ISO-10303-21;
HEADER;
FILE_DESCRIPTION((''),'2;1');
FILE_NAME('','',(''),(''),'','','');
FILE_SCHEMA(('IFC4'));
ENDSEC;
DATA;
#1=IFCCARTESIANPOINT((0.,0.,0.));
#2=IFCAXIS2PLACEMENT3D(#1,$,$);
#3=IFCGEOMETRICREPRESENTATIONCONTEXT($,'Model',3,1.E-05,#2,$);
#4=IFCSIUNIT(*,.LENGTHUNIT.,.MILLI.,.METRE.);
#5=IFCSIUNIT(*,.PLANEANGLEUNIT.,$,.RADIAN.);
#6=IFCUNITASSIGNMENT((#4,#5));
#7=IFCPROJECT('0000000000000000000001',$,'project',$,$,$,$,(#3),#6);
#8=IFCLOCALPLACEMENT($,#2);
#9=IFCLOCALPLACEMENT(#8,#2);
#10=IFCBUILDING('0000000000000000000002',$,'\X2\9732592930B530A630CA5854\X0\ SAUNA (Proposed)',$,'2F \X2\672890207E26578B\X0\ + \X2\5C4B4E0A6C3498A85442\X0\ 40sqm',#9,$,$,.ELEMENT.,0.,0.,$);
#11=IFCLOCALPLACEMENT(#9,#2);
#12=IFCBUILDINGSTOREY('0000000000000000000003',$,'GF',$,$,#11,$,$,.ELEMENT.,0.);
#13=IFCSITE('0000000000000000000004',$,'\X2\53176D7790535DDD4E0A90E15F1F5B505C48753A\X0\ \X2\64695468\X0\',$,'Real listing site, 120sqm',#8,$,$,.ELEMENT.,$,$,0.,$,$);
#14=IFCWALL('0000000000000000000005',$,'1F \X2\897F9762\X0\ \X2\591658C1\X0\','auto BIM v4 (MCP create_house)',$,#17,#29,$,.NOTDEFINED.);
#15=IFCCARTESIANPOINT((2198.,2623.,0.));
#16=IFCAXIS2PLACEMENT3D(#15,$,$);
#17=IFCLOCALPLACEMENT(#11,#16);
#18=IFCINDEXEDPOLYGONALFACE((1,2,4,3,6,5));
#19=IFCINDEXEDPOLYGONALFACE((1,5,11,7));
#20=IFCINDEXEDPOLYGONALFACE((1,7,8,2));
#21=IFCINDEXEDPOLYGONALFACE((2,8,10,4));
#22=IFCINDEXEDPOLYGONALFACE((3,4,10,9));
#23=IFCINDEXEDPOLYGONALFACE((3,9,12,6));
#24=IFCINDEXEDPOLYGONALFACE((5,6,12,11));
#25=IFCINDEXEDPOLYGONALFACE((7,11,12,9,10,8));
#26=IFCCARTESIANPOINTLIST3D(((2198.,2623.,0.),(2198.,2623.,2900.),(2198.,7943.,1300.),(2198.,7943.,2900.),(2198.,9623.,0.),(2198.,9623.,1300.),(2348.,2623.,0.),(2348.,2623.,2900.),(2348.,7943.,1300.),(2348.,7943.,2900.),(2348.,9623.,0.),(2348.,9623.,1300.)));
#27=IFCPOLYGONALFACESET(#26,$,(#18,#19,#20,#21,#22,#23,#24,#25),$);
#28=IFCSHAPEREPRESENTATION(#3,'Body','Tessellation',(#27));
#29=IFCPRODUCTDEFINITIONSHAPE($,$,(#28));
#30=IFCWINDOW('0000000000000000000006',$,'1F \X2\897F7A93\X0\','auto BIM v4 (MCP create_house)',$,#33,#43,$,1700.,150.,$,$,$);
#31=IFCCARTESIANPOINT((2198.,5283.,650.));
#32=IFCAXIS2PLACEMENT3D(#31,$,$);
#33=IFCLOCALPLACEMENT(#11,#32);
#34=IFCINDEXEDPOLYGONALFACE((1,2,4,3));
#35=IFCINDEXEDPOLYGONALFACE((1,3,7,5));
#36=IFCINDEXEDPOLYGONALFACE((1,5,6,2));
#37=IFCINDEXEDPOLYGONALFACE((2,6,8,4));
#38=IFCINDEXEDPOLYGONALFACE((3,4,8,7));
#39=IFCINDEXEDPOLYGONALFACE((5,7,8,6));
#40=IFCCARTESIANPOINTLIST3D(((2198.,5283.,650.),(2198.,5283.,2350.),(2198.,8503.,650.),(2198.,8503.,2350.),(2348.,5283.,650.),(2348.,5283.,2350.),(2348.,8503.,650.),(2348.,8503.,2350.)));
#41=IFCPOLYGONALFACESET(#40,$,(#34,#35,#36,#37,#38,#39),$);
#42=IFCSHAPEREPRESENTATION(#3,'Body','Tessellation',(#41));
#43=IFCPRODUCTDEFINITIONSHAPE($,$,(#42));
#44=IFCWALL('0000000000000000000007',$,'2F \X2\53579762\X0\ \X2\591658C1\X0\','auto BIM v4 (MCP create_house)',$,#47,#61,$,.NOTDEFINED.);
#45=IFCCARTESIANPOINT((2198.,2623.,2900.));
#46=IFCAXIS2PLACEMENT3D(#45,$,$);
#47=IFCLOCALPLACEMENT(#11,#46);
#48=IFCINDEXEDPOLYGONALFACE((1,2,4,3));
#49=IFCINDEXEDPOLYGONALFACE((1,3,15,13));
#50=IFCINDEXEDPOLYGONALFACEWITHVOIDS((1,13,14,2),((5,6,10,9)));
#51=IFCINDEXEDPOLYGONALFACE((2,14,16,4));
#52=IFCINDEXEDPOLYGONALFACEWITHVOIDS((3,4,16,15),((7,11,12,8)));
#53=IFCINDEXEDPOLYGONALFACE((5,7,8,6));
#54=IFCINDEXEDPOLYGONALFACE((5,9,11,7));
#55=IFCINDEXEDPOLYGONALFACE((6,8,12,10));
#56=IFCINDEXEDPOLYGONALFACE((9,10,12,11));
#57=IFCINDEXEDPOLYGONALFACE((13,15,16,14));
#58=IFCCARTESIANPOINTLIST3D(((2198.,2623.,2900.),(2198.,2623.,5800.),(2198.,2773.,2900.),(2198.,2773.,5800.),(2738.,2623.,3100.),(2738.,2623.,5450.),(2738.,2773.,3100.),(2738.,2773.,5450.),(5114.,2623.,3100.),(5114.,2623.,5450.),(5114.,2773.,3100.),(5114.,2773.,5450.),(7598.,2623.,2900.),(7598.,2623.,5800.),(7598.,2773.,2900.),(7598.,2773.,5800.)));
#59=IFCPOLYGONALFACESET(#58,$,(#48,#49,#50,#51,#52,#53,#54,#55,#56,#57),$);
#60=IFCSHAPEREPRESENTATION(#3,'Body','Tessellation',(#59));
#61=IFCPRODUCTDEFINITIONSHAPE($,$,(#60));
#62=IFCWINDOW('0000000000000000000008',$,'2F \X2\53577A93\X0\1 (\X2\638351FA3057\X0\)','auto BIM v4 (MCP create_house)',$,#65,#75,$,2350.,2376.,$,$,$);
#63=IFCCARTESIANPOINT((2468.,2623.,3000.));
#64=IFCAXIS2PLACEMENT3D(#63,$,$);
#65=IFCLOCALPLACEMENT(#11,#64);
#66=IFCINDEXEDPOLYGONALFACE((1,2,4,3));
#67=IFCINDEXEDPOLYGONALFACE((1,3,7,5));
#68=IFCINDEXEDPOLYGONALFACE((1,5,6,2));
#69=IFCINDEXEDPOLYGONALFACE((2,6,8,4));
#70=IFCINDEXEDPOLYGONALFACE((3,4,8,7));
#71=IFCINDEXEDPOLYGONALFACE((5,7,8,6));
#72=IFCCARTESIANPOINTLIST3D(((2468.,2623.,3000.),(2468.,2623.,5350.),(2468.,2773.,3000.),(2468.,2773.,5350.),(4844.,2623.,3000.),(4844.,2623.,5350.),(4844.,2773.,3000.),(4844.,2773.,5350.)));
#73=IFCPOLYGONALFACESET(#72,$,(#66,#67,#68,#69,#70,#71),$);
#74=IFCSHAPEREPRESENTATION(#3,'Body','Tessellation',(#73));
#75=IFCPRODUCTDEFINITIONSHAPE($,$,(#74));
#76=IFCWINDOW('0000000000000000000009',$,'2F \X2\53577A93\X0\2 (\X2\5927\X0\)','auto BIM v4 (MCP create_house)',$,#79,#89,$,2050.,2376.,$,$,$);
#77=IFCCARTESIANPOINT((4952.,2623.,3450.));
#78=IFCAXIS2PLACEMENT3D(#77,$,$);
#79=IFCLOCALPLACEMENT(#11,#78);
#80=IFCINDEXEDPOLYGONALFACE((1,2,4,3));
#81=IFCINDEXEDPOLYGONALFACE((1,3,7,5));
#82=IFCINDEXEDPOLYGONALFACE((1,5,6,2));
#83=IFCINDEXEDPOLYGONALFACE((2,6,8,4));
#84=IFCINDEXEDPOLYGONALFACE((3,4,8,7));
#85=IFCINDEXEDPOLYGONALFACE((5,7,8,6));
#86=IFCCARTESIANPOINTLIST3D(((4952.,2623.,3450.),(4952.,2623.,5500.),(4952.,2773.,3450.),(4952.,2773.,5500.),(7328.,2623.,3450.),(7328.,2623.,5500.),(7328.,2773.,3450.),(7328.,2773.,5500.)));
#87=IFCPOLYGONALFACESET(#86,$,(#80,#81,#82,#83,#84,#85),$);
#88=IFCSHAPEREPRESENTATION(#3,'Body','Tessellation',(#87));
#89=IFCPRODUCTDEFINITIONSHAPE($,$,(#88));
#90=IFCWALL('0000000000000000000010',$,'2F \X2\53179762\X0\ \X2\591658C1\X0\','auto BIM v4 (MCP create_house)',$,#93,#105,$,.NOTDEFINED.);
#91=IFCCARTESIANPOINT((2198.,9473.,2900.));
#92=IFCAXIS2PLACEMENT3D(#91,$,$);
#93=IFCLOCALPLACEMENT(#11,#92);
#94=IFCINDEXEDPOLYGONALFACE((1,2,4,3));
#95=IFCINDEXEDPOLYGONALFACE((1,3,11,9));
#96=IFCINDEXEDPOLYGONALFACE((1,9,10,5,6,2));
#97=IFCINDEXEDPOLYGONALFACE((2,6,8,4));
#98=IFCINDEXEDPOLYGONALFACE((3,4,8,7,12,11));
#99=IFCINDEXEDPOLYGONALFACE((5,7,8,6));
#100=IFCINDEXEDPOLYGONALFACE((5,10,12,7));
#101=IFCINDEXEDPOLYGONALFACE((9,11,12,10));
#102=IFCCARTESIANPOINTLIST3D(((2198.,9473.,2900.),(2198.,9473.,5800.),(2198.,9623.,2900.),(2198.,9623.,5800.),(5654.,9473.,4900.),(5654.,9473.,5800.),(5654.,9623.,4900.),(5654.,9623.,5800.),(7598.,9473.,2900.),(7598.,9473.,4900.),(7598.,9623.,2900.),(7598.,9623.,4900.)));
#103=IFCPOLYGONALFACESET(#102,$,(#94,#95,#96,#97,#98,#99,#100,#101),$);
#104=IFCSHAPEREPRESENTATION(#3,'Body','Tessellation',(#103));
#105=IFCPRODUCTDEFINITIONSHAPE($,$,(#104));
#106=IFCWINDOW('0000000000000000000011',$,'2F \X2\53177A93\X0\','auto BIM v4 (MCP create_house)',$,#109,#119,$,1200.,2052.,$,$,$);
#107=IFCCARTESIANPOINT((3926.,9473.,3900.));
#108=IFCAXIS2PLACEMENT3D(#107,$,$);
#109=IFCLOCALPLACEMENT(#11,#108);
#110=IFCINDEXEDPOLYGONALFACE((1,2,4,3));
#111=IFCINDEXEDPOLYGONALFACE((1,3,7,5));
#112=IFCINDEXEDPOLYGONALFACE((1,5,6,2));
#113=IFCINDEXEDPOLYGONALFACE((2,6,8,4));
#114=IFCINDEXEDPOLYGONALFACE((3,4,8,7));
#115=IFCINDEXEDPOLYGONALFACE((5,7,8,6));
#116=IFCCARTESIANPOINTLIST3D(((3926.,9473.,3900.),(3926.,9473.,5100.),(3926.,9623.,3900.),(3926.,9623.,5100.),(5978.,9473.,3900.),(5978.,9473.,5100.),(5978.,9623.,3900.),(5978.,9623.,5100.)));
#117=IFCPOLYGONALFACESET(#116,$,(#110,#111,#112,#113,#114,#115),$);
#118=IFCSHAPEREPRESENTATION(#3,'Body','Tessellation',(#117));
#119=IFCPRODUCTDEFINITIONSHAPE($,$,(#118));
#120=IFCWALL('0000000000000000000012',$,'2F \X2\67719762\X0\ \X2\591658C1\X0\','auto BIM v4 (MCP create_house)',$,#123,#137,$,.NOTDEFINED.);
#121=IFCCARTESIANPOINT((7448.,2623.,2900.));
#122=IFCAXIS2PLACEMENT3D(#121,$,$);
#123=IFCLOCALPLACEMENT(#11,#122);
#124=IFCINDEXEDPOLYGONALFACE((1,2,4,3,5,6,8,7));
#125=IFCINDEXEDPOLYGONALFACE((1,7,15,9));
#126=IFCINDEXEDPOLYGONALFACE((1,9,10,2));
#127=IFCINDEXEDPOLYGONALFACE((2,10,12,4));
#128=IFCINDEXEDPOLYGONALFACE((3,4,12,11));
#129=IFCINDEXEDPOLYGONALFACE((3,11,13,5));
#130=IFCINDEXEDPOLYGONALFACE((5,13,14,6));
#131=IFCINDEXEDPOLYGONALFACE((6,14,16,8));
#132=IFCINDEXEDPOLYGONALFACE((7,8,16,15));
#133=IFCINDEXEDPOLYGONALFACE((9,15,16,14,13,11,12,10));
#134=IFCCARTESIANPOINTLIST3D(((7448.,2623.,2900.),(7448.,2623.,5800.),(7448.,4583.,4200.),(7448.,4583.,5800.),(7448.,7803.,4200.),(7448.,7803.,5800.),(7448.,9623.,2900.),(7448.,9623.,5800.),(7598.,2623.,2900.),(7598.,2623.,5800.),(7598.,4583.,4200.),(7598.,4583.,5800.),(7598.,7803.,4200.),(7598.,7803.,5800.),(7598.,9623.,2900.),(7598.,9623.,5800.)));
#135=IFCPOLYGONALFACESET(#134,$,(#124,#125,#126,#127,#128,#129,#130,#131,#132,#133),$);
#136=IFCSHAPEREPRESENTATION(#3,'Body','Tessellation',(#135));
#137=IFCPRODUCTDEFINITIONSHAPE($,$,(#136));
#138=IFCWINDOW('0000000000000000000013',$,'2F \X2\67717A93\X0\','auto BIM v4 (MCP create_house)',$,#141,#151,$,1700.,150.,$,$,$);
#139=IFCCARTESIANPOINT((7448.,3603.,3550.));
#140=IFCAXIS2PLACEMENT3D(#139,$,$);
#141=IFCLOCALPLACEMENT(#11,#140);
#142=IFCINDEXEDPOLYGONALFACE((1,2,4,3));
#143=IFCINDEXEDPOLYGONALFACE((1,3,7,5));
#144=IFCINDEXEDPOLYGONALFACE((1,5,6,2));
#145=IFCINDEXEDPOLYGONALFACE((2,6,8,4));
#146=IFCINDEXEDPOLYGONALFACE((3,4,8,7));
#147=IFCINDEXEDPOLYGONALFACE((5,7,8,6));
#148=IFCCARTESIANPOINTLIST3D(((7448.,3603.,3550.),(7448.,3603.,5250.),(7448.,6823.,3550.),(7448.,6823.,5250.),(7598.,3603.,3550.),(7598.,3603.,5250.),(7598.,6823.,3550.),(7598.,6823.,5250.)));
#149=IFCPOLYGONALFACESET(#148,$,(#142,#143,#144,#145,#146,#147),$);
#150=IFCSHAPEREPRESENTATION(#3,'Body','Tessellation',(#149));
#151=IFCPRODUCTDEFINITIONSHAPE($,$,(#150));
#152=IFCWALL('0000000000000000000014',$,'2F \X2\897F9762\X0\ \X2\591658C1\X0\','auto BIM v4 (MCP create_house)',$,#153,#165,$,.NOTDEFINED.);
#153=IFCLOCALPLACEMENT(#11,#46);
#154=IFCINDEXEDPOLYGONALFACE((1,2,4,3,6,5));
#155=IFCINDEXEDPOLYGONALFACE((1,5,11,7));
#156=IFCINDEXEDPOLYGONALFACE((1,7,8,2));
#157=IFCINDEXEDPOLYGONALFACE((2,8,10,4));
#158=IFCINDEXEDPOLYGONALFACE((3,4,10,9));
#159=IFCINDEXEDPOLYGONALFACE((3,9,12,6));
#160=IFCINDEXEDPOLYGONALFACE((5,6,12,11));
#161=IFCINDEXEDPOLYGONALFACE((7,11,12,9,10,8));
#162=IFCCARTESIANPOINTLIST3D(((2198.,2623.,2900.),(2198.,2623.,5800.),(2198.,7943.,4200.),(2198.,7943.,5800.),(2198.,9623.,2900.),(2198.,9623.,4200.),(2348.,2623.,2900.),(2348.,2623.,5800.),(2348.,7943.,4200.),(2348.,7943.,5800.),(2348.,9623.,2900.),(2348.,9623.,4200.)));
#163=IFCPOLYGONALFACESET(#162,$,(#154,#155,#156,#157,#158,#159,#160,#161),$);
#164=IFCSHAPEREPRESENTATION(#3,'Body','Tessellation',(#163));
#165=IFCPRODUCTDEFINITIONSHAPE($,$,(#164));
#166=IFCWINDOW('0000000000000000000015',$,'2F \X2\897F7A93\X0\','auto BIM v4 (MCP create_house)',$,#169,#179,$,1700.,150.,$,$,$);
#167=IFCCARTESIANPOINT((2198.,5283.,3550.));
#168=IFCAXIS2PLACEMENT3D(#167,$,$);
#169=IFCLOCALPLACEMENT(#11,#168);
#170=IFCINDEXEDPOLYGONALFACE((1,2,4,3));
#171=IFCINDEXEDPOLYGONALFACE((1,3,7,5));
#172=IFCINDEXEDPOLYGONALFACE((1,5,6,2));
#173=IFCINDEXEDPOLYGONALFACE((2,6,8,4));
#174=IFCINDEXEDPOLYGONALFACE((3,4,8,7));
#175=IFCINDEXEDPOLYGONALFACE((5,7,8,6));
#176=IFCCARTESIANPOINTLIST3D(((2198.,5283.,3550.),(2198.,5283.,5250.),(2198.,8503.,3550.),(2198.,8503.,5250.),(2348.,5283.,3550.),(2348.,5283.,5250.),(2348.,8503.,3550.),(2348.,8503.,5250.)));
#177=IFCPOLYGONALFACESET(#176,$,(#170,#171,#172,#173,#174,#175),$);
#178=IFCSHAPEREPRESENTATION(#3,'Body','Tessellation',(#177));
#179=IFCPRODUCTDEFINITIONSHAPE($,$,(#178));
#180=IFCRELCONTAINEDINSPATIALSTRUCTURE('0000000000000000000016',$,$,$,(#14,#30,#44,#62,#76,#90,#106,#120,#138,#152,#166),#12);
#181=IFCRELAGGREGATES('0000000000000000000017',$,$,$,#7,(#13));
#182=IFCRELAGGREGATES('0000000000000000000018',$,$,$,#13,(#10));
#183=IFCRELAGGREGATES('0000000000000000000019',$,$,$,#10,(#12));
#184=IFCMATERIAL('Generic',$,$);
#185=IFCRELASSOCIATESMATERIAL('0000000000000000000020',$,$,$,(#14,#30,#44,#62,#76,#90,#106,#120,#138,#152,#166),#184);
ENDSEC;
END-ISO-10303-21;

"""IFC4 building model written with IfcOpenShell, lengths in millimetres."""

from ifc_helpers import new_model, si_unit, frame, frame_2d, origin, place, context, project, spatial, rectangle, extrude, material, element, fill, save


model = new_model("IFC4")

# Units and contexts
model_context = context("Model", 3, precision=1e-05, world=origin())
ifc_project = project(units=[si_unit("LENGTHUNIT", "METRE", prefix="MILLI"), si_unit("PLANEANGLEUNIT", "RADIAN")], contexts=[model_context])

# Site, building, storey
site_placement = place(None, origin())
site = spatial("IfcSite", under=ifc_project, at=site_placement, Name="北海道川上郡弟子屈町 摩周", ObjectType="Real listing site, 120sqm", CompositionType="ELEMENT", RefElevation=0.0)
building_placement = place(site_placement, origin())
building = spatial("IfcBuilding", under=site, at=building_placement, Name="露天サウナ塔 SAUNA (Proposed)", ObjectType="2F 木造縦型 + 屋上水風呂 40sqm", CompositionType="ELEMENT", ElevationOfRefHeight=0.0, ElevationOfTerrain=0.0)
storey_placement = place(building_placement, origin())
storey = spatial("IfcBuildingStorey", under=building, at=storey_placement, Name="GF", CompositionType="ELEMENT", Elevation=0.0)

# Shared definitions
ifc_material = material(Name="Generic")

# Wall, opening, window
wall_1_placement = place(storey_placement, frame((2198.0, 2623.0, 0.0)))
wall_1 = element("IfcWall", 1, at=wall_1_placement, inside=storey, material=ifc_material, Name="1F 西面 外壁", Description="auto BIM v4 (MCP create_house)", PredefinedType="NOTDEFINED", context=model_context, shape_type="SweptSolid", body=[
    extrude(rectangle(XDim=150.0, YDim=7000.0, at=frame_2d((75.0, 3500.0))), frame((2198.0, 2623.0, 0.0)), (0.0, 0.0, 1.0), 2900.0),
])
opening_1_placement = place(storey_placement, frame((2198.0, 5283.0, 650.0)))
opening_1 = element("IfcOpeningElement", 2, at=opening_1_placement, cuts=wall_1, PredefinedType="NOTDEFINED", context=model_context, shape_type="SweptSolid", body=[
    extrude(rectangle(XDim=150.0, YDim=3220.0, at=frame_2d((75.0, 1610.0))), frame((2198.0, 5283.0, 650.0)), (0.0, 0.0, 1.0), 1700.0),
])
window_1_placement = place(storey_placement, frame((2198.0, 5283.0, 650.0)))
window_1 = element("IfcWindow", 3, at=window_1_placement, inside=storey, material=ifc_material, Name="1F 西窓", Description="auto BIM v4 (MCP create_house)", OverallHeight=1700.0, OverallWidth=150.0, context=model_context, shape_type="SweptSolid", body=[
    extrude(rectangle(XDim=150.0, YDim=3220.0, at=frame_2d((75.0, 1610.0))), frame((2198.0, 5283.0, 650.0)), (0.0, 0.0, 1.0), 1700.0),
])
fill(opening_1, window_1)

# Wall, openings, windows
wall_2_placement = place(storey_placement, frame((2198.0, 2623.0, 2900.0)))
wall_2 = element("IfcWall", 4, at=wall_2_placement, inside=storey, material=ifc_material, Name="2F 南面 外壁", Description="auto BIM v4 (MCP create_house)", PredefinedType="NOTDEFINED", context=model_context, shape_type="SweptSolid", body=[
    extrude(rectangle(XDim=5400.0, YDim=150.0, at=frame_2d((2700.0, 75.0))), frame((2198.0, 2623.0, 2900.0)), (0.0, 0.0, 1.0), 2900.0),
])
opening_2_placement = place(storey_placement, frame((2468.0, 2623.0, 3000.0)))
opening_2 = element("IfcOpeningElement", 5, at=opening_2_placement, cuts=wall_2, PredefinedType="NOTDEFINED", context=model_context, shape_type="SweptSolid", body=[
    extrude(rectangle(XDim=2376.0, YDim=150.0, at=frame_2d((1188.0, 75.0))), frame((2468.0, 2623.0, 3000.0)), (0.0, 0.0, 1.0), 2350.0),
])
opening_3_placement = place(storey_placement, frame((4952.0, 2623.0, 3450.0)))
opening_3 = element("IfcOpeningElement", 6, at=opening_3_placement, cuts=wall_2, PredefinedType="NOTDEFINED", context=model_context, shape_type="SweptSolid", body=[
    extrude(rectangle(XDim=2376.0, YDim=150.0, at=frame_2d((1188.0, 75.0))), frame((4952.0, 2623.0, 3450.0)), (0.0, 0.0, 1.0), 2050.0),
])
window_2_placement = place(storey_placement, frame((2468.0, 2623.0, 3000.0)))
window_2 = element("IfcWindow", 7, at=window_2_placement, inside=storey, material=ifc_material, Name="2F 南窓1 (掃出し)", Description="auto BIM v4 (MCP create_house)", OverallHeight=2350.0, OverallWidth=2376.0, context=model_context, shape_type="SweptSolid", body=[
    extrude(rectangle(XDim=2376.0, YDim=150.0, at=frame_2d((1188.0, 75.0))), frame((2468.0, 2623.0, 3000.0)), (0.0, 0.0, 1.0), 2350.0),
])
fill(opening_2, window_2)
window_3_placement = place(storey_placement, frame((4952.0, 2623.0, 3450.0)))
window_3 = element("IfcWindow", 8, at=window_3_placement, inside=storey, material=ifc_material, Name="2F 南窓2 (大)", Description="auto BIM v4 (MCP create_house)", OverallHeight=2050.0, OverallWidth=2376.0, context=model_context, shape_type="SweptSolid", body=[
    extrude(rectangle(XDim=2376.0, YDim=150.0, at=frame_2d((1188.0, 75.0))), frame((4952.0, 2623.0, 3450.0)), (0.0, 0.0, 1.0), 2050.0),
])
fill(opening_3, window_3)

# Walls, openings, windows
wall_3_placement = place(storey_placement, frame((2198.0, 9473.0, 2900.0)))
wall_3 = element("IfcWall", 9, at=wall_3_placement, inside=storey, material=ifc_material, Name="2F 北面 外壁", Description="auto BIM v4 (MCP create_house)", PredefinedType="NOTDEFINED", context=model_context, shape_type="SweptSolid", body=[
    extrude(rectangle(XDim=5400.0, YDim=150.0, at=frame_2d((2700.0, 75.0))), frame((2198.0, 9473.0, 2900.0)), (0.0, 0.0, 1.0), 2900.0),
])
opening_4_placement = place(storey_placement, frame((3926.0, 9473.0, 3900.0)))
opening_4 = element("IfcOpeningElement", 10, at=opening_4_placement, cuts=wall_3, PredefinedType="NOTDEFINED", context=model_context, shape_type="SweptSolid", body=[
    extrude(rectangle(XDim=2052.0, YDim=150.0, at=frame_2d((1026.0, 75.0))), frame((3926.0, 9473.0, 3900.0)), (0.0, 0.0, 1.0), 1200.0),
])
window_4_placement = place(storey_placement, frame((3926.0, 9473.0, 3900.0)))
window_4 = element("IfcWindow", 11, at=window_4_placement, inside=storey, material=ifc_material, Name="2F 北窓", Description="auto BIM v4 (MCP create_house)", OverallHeight=1200.0, OverallWidth=2052.0, context=model_context, shape_type="SweptSolid", body=[
    extrude(rectangle(XDim=2052.0, YDim=150.0, at=frame_2d((1026.0, 75.0))), frame((3926.0, 9473.0, 3900.0)), (0.0, 0.0, 1.0), 1200.0),
])
fill(opening_4, window_4)
wall_4_placement = place(storey_placement, frame((7448.0, 2623.0, 2900.0)))
wall_4 = element("IfcWall", 12, at=wall_4_placement, inside=storey, material=ifc_material, Name="2F 東面 外壁", Description="auto BIM v4 (MCP create_house)", PredefinedType="NOTDEFINED", context=model_context, shape_type="SweptSolid", body=[
    extrude(rectangle(XDim=150.0, YDim=7000.0, at=frame_2d((75.0, 3500.0))), frame((7448.0, 2623.0, 2900.0)), (0.0, 0.0, 1.0), 2900.0),
])
opening_5_placement = place(storey_placement, frame((7448.0, 3603.0, 3550.0)))
opening_5 = element("IfcOpeningElement", 13, at=opening_5_placement, cuts=wall_4, PredefinedType="NOTDEFINED", context=model_context, shape_type="SweptSolid", body=[
    extrude(rectangle(XDim=150.0, YDim=3220.0, at=frame_2d((75.0, 1610.0))), frame((7448.0, 3603.0, 3550.0)), (0.0, 0.0, 1.0), 1700.0),
])
window_5_placement = place(storey_placement, frame((7448.0, 3603.0, 3550.0)))
window_5 = element("IfcWindow", 14, at=window_5_placement, inside=storey, material=ifc_material, Name="2F 東窓", Description="auto BIM v4 (MCP create_house)", OverallHeight=1700.0, OverallWidth=150.0, context=model_context, shape_type="SweptSolid", body=[
    extrude(rectangle(XDim=150.0, YDim=3220.0, at=frame_2d((75.0, 1610.0))), frame((7448.0, 3603.0, 3550.0)), (0.0, 0.0, 1.0), 1700.0),
])
fill(opening_5, window_5)
wall_5_placement = place(storey_placement, frame((2198.0, 2623.0, 2900.0)))
wall_5 = element("IfcWall", 15, at=wall_5_placement, inside=storey, material=ifc_material, Name="2F 西面 外壁", Description="auto BIM v4 (MCP create_house)", PredefinedType="NOTDEFINED", context=model_context, shape_type="SweptSolid", body=[
    extrude(rectangle(XDim=150.0, YDim=7000.0, at=frame_2d((75.0, 3500.0))), frame((2198.0, 2623.0, 2900.0)), (0.0, 0.0, 1.0), 2900.0),
])
opening_6_placement = place(storey_placement, frame((2198.0, 5283.0, 3550.0)))
opening_6 = element("IfcOpeningElement", 16, at=opening_6_placement, cuts=wall_5, PredefinedType="NOTDEFINED", context=model_context, shape_type="SweptSolid", body=[
    extrude(rectangle(XDim=150.0, YDim=3220.0, at=frame_2d((75.0, 1610.0))), frame((2198.0, 5283.0, 3550.0)), (0.0, 0.0, 1.0), 1700.0),
])
window_6_placement = place(storey_placement, frame((2198.0, 5283.0, 3550.0)))
window_6 = element("IfcWindow", 17, at=window_6_placement, inside=storey, material=ifc_material, Name="2F 西窓", Description="auto BIM v4 (MCP create_house)", OverallHeight=1700.0, OverallWidth=150.0, context=model_context, shape_type="SweptSolid", body=[
    extrude(rectangle(XDim=150.0, YDim=3220.0, at=frame_2d((75.0, 1610.0))), frame((2198.0, 5283.0, 3550.0)), (0.0, 0.0, 1.0), 1700.0),
])
fill(opening_6, window_6)

save(model, "model.ifc")
